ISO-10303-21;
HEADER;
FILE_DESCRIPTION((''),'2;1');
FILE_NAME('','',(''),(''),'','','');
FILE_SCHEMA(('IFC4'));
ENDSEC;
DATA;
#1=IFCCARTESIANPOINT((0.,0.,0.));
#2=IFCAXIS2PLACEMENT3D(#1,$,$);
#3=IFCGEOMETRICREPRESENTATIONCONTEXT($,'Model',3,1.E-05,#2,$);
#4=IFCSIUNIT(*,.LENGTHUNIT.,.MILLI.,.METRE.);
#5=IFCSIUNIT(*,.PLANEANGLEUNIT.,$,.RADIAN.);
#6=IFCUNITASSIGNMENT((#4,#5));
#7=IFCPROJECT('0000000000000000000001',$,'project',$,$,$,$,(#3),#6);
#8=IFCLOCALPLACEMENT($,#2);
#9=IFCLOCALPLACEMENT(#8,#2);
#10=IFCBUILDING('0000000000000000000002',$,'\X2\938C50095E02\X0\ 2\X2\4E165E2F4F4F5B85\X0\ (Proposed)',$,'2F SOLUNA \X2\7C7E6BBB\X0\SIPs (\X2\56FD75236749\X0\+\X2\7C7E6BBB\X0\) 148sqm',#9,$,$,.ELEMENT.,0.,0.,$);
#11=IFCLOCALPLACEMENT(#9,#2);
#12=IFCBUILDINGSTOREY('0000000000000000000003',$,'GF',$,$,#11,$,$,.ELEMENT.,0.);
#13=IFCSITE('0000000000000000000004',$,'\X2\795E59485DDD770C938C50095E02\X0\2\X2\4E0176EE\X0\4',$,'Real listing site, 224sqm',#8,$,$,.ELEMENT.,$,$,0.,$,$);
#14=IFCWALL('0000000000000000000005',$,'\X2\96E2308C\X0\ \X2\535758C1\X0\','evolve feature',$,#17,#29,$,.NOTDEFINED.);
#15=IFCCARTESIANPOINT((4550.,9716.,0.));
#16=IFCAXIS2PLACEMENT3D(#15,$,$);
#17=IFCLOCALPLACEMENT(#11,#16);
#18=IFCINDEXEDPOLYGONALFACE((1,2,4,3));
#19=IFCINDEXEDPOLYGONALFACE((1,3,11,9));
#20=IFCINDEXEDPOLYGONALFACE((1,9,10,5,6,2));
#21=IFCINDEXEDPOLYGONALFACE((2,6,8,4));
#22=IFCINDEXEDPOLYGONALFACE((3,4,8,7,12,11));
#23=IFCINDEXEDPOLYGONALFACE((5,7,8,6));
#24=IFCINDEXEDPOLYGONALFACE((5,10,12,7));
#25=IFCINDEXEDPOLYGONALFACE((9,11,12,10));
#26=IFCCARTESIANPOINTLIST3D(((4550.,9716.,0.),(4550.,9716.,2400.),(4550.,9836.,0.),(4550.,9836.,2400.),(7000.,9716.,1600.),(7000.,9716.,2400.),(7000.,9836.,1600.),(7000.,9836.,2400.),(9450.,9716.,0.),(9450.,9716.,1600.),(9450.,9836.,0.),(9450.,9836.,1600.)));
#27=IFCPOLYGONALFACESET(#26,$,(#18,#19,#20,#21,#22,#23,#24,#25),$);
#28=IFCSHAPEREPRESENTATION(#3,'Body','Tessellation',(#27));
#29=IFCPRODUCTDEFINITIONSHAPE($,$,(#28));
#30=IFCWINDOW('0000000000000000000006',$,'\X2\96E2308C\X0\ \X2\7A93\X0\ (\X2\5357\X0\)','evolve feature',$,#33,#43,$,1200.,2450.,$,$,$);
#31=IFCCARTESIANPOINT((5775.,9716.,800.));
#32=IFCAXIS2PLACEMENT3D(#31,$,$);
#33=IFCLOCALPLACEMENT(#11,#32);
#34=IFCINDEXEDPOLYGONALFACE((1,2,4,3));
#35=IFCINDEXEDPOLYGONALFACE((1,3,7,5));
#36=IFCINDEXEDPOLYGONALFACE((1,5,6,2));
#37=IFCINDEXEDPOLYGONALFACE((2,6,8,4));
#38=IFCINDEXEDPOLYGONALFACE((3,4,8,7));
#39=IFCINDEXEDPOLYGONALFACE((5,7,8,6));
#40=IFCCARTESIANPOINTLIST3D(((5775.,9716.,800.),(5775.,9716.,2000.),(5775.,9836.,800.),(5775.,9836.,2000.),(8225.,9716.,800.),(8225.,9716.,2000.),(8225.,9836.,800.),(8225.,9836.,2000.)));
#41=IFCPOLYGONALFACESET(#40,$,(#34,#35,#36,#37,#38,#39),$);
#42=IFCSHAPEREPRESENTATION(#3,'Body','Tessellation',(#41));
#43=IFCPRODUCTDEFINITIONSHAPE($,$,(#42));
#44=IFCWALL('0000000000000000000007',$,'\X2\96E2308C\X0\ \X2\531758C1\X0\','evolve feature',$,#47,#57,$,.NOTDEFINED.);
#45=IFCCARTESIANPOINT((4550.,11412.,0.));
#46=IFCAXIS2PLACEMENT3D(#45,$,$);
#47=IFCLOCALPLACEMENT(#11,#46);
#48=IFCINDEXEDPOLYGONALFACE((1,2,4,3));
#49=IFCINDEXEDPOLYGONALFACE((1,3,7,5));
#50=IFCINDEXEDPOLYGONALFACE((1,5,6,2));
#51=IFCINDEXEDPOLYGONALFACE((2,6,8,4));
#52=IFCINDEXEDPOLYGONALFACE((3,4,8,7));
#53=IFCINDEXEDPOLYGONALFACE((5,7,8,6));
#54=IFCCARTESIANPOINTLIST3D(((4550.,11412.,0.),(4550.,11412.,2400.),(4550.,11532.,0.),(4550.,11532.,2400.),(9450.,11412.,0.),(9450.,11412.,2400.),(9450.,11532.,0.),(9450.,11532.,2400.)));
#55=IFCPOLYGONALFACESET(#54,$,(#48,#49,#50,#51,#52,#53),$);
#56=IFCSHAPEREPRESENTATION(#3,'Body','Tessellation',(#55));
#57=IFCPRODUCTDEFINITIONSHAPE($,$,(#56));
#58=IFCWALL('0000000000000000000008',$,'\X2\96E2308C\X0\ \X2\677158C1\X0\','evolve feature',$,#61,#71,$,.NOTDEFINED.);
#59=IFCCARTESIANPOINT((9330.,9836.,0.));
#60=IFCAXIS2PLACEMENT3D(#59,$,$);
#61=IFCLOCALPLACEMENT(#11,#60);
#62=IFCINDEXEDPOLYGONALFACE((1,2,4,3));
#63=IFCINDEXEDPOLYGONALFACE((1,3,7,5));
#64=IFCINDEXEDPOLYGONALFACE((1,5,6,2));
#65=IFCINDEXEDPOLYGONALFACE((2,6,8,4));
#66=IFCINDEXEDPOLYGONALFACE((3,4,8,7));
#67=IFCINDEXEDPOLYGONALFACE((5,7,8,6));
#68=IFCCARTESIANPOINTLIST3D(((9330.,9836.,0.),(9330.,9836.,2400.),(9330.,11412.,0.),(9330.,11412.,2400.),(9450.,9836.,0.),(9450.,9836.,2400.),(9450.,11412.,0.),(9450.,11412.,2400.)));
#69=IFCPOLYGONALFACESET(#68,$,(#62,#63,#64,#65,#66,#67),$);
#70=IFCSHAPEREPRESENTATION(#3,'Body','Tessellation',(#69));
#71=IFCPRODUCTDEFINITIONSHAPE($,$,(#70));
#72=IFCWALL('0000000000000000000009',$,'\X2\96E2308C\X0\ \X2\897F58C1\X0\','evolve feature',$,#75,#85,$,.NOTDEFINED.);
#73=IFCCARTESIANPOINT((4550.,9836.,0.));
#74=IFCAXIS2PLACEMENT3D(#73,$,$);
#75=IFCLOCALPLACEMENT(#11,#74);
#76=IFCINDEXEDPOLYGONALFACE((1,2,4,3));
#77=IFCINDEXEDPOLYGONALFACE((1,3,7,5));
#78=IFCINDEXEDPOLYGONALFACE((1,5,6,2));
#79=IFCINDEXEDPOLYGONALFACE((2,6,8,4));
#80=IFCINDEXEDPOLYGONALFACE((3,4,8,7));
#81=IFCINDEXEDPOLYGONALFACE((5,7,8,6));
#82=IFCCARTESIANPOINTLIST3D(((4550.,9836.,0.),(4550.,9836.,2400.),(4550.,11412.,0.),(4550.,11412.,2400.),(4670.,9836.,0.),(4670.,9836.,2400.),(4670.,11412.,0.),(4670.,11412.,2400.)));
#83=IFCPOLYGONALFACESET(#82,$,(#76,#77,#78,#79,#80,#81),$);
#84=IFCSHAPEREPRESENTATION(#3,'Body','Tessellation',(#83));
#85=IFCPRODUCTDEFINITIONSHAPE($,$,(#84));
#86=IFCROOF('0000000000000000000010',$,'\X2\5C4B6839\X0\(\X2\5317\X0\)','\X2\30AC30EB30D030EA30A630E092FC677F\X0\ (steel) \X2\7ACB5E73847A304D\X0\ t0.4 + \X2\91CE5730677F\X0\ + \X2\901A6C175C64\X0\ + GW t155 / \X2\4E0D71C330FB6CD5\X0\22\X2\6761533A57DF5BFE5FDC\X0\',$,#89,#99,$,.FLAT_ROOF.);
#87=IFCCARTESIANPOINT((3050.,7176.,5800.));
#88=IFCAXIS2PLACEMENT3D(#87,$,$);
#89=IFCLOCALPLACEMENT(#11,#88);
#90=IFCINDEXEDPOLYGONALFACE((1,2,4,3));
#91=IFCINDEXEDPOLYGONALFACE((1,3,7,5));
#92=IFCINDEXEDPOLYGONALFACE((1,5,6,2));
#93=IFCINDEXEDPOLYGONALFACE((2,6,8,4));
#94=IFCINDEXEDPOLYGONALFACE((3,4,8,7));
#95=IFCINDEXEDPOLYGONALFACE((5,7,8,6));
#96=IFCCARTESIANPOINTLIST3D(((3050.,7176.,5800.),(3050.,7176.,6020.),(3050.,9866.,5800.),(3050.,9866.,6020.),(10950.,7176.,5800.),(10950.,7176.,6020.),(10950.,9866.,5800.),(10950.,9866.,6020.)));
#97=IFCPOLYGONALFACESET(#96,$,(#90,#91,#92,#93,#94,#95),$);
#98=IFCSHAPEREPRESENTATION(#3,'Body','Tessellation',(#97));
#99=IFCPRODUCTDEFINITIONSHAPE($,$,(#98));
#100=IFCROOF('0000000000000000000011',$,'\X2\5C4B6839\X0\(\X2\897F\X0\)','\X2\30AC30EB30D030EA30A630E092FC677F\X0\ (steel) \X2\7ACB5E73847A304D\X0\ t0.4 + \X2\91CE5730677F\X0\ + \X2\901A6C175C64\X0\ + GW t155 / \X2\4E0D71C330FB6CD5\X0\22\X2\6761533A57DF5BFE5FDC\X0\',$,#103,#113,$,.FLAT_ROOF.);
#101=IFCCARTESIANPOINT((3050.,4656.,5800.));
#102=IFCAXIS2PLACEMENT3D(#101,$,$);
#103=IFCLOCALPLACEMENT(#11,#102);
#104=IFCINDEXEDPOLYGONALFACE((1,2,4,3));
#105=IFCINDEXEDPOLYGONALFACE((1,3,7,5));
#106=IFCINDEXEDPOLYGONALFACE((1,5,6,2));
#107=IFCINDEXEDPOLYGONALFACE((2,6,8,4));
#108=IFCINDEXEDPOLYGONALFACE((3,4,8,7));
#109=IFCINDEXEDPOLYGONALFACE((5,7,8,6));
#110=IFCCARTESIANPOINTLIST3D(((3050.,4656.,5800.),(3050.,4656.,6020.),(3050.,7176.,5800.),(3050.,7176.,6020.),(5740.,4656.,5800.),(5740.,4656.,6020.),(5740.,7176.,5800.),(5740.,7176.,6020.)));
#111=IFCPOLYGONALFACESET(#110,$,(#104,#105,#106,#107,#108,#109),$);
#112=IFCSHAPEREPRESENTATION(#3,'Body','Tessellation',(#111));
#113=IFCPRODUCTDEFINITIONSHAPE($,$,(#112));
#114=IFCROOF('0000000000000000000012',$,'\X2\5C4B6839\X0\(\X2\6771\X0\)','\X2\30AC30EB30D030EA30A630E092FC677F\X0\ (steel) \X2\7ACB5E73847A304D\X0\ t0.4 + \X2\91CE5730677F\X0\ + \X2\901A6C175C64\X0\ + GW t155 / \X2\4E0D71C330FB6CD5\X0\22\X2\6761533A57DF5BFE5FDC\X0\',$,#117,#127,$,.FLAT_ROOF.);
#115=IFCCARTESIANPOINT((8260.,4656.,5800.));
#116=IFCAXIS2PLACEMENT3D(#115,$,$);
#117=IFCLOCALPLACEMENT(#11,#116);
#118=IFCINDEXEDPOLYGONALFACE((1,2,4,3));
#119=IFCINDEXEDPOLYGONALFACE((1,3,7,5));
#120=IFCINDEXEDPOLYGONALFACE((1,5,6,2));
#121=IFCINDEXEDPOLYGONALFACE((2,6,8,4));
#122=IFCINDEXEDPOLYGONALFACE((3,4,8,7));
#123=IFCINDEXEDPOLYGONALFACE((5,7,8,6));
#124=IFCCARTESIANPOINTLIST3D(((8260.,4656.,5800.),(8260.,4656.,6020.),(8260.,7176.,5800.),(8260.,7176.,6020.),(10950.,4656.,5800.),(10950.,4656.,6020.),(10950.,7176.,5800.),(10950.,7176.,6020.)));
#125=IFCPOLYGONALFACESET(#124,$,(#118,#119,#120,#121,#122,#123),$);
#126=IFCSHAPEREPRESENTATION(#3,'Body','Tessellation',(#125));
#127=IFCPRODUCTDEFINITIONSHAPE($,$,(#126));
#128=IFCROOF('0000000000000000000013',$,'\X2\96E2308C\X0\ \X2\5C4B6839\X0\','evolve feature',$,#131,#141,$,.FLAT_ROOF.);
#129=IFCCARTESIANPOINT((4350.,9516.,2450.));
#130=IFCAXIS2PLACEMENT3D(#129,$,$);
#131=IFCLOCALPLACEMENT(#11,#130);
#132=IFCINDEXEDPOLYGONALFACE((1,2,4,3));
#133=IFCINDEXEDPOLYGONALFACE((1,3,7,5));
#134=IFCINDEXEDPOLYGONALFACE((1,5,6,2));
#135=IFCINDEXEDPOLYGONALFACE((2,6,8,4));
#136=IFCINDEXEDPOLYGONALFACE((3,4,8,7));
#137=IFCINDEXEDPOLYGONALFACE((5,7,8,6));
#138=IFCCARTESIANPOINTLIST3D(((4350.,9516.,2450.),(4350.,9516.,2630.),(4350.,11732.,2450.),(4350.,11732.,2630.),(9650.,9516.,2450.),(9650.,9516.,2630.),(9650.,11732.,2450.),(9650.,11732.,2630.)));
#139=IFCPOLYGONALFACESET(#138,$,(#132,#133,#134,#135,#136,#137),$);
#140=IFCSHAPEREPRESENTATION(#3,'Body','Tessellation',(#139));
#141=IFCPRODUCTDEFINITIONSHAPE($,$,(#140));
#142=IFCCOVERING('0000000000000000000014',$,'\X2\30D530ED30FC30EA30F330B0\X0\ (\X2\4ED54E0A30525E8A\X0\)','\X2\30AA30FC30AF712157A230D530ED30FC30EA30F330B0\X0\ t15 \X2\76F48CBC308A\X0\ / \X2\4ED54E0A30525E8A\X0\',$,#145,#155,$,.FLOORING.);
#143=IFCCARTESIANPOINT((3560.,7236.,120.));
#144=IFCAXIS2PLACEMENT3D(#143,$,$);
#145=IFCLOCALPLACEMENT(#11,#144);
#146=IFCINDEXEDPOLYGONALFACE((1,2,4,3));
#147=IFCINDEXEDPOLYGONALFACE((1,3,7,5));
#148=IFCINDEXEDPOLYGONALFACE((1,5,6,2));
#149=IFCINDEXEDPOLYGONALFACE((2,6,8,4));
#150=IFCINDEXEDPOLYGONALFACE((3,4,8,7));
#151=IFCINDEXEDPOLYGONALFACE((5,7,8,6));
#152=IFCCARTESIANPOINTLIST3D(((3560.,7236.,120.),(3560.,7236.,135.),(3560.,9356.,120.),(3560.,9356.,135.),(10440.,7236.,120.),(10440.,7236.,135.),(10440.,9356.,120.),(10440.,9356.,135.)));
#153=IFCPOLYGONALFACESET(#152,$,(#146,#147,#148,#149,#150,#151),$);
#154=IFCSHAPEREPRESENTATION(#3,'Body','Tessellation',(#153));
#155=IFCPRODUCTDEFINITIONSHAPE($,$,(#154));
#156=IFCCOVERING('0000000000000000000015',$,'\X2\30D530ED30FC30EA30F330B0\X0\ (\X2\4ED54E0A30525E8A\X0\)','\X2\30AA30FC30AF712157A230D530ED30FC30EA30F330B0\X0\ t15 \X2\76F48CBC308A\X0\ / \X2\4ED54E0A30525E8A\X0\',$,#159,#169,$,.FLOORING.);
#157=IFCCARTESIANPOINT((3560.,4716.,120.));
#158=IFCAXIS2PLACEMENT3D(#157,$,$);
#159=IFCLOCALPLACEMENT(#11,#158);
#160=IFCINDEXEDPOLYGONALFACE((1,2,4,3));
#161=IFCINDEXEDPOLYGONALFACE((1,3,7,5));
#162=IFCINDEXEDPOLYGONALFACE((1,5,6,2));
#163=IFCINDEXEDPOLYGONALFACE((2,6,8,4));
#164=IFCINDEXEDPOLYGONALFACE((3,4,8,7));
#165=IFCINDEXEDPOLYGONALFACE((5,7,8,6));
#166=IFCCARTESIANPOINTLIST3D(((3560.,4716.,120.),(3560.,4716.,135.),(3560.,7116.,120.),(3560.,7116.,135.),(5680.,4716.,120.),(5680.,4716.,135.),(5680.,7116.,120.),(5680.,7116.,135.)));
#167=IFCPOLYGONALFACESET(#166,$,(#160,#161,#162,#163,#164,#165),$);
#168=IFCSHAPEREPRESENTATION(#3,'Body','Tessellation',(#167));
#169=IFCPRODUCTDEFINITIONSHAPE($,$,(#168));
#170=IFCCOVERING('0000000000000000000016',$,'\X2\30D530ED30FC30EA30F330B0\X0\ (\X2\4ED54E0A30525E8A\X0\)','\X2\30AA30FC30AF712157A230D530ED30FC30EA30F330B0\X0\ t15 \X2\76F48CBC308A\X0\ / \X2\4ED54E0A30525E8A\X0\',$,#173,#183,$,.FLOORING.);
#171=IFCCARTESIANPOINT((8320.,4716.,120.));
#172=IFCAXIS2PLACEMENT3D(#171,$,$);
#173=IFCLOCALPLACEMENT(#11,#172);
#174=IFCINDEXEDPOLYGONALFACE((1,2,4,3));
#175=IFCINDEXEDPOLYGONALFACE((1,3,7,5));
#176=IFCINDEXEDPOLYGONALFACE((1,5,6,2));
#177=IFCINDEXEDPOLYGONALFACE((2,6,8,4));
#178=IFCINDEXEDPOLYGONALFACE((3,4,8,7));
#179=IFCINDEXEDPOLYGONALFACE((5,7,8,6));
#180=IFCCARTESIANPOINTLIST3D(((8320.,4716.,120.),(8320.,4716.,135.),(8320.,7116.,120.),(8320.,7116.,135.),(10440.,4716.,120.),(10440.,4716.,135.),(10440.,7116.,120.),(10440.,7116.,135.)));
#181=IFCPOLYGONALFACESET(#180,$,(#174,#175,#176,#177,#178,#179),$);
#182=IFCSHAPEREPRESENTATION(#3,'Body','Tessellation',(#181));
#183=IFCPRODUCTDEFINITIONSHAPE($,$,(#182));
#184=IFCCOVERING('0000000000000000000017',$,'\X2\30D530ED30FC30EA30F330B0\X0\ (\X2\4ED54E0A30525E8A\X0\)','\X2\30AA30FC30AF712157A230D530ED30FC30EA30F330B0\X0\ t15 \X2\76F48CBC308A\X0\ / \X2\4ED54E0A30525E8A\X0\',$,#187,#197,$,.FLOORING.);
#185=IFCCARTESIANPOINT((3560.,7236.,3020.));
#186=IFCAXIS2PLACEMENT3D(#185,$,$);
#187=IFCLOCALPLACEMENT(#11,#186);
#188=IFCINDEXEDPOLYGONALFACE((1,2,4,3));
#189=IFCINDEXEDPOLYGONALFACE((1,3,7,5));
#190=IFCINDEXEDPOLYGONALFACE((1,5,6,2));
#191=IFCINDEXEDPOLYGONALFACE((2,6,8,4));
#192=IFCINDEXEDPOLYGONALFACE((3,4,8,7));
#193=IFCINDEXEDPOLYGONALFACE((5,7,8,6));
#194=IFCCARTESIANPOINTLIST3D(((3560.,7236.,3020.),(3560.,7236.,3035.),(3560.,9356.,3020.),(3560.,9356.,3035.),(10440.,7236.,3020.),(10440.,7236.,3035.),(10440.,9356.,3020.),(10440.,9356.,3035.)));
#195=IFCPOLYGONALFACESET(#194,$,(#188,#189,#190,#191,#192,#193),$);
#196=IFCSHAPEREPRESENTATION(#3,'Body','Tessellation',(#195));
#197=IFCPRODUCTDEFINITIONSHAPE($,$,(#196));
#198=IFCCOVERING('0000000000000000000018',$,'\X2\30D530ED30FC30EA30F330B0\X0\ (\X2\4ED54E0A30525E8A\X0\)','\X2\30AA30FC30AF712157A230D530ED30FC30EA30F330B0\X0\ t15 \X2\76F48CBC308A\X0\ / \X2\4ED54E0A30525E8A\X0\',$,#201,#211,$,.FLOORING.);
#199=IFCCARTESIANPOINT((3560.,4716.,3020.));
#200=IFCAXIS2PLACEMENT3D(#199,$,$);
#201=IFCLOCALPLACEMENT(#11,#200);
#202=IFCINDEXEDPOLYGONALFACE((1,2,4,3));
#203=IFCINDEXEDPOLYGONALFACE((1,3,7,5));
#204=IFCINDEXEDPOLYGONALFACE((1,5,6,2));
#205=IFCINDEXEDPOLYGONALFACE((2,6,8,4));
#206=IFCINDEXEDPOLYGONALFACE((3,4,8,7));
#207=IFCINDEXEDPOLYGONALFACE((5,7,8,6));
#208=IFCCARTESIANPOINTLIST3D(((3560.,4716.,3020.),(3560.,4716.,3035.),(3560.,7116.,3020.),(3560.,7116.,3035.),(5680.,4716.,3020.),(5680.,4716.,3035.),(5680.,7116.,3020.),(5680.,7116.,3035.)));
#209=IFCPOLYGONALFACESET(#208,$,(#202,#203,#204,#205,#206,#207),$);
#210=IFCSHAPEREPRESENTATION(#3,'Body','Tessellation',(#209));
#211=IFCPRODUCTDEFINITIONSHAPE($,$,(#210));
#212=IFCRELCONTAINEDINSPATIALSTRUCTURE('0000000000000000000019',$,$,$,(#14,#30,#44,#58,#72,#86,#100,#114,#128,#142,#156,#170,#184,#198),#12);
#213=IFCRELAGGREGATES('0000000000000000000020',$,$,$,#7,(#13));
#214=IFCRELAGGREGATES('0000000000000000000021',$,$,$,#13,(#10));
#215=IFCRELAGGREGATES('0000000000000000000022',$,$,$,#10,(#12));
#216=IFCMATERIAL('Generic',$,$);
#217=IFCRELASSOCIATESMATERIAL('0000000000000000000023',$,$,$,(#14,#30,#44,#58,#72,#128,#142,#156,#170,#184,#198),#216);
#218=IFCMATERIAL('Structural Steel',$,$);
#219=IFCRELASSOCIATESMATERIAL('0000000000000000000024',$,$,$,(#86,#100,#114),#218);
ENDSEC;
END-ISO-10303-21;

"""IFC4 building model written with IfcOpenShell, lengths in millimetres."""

from ifc_helpers import new_model, si_unit, frame, frame_2d, origin, place, context, project, spatial, rectangle, extrude, material, element, fill, save


model = new_model("IFC4")

# Units and contexts
model_context = context("Model", 3, precision=1e-05, world=origin())
ifc_project = project(units=[si_unit("LENGTHUNIT", "METRE", prefix="MILLI"), si_unit("PLANEANGLEUNIT", "RADIAN")], contexts=[model_context])

# Site, building, storey
site_placement = place(None, origin())
site = spatial("IfcSite", under=ifc_project, at=site_placement, Name="神奈川県鎌倉市2丁目4", ObjectType="Real listing site, 224sqm", CompositionType="ELEMENT", RefElevation=0.0)
building_placement = place(site_placement, origin())
building = spatial("IfcBuilding", under=site, at=building_placement, Name="鎌倉市 2世帯住宅 (Proposed)", ObjectType="2F SOLUNA 籾殻SIPs (国産杉+籾殻) 148sqm", CompositionType="ELEMENT", ElevationOfRefHeight=0.0, ElevationOfTerrain=0.0)
storey_placement = place(building_placement, origin())
storey = spatial("IfcBuildingStorey", under=building, at=storey_placement, Name="GF", CompositionType="ELEMENT", Elevation=0.0)

# Shared definitions
ifc_material_1 = material(Name="Generic")

# Wall, opening, window
wall_1_placement = place(storey_placement, frame((4550.0, 9716.0, 0.0)))
wall_1 = element("IfcWall", 1, at=wall_1_placement, inside=storey, material=ifc_material_1, Name="離れ 南壁", Description="evolve feature", PredefinedType="NOTDEFINED", context=model_context, shape_type="SweptSolid", body=[
    extrude(rectangle(XDim=4900.0, YDim=120.0, at=frame_2d((2450.0, 60.0))), frame((4550.0, 9716.0, 0.0)), (0.0, 0.0, 1.0), 2400.0),
])
opening_1_placement = place(storey_placement, frame((5775.0, 9716.0, 800.0)))
opening_1 = element("IfcOpeningElement", 2, at=opening_1_placement, cuts=wall_1, PredefinedType="NOTDEFINED", context=model_context, shape_type="SweptSolid", body=[
    extrude(rectangle(XDim=2450.0, YDim=120.0, at=frame_2d((1225.0, 60.0))), frame((5775.0, 9716.0, 800.0)), (0.0, 0.0, 1.0), 1200.0),
])
window_1_placement = place(storey_placement, frame((5775.0, 9716.0, 800.0)))
window_1 = element("IfcWindow", 3, at=window_1_placement, inside=storey, material=ifc_material_1, Name="離れ 窓 (南)", Description="evolve feature", OverallHeight=1200.0, OverallWidth=2450.0, context=model_context, shape_type="SweptSolid", body=[
    extrude(rectangle(XDim=2450.0, YDim=120.0, at=frame_2d((1225.0, 60.0))), frame((5775.0, 9716.0, 800.0)), (0.0, 0.0, 1.0), 1200.0),
])
fill(opening_1, window_1)

# Walls
wall_2_placement = place(storey_placement, frame((4550.0, 11412.0, 0.0)))
element("IfcWall", 4, at=wall_2_placement, inside=storey, material=ifc_material_1, Name="離れ 北壁", Description="evolve feature", PredefinedType="NOTDEFINED", context=model_context, shape_type="SweptSolid", body=[
    extrude(rectangle(XDim=4900.0, YDim=120.0, at=frame_2d((2450.0, 60.0))), frame((4550.0, 11412.0, 0.0)), (0.0, 0.0, 1.0), 2400.0),
])
wall_3_placement = place(storey_placement, frame((9330.0, 9836.0, 0.0)))
element("IfcWall", 5, at=wall_3_placement, inside=storey, material=ifc_material_1, Name="離れ 東壁", Description="evolve feature", PredefinedType="NOTDEFINED", context=model_context, shape_type="SweptSolid", body=[
    extrude(rectangle(XDim=120.0, YDim=1576.0, at=frame_2d((60.0, 788.0))), frame((9330.0, 9836.0, 0.0)), (0.0, 0.0, 1.0), 2400.0),
])
wall_4_placement = place(storey_placement, frame((4550.0, 9836.0, 0.0)))
element("IfcWall", 6, at=wall_4_placement, inside=storey, material=ifc_material_1, Name="離れ 西壁", Description="evolve feature", PredefinedType="NOTDEFINED", context=model_context, shape_type="SweptSolid", body=[
    extrude(rectangle(XDim=120.0, YDim=1576.0, at=frame_2d((60.0, 788.0))), frame((4550.0, 9836.0, 0.0)), (0.0, 0.0, 1.0), 2400.0),
])

# Roofs
ifc_material_2 = material(Name="Structural Steel")
for number, where, name in (
    (7, (3050.0, 7176.0, 5800.0), "屋根(北)"),
):
    element("IfcRoof", number, at=place(storey_placement, frame(where)), inside=storey, material=ifc_material_2, Name=name, Description="ガルバリウム鋼板 (steel) 立平葺き t0.4 + 野地板 + 通気層 + GW t155 / 不燃・法22条区域対応", PredefinedType="FLAT_ROOF", context=model_context, shape_type="SweptSolid", body=[
        extrude(rectangle(XDim=7900.0, YDim=2690.0, at=frame_2d((3950.0, 1345.0))), frame((3050.0, 7176.0, 5800.0)), (0.0, 0.0, 1.0), 220.0),
    ])
roof_1_placement = place(storey_placement, frame((3050.0, 4656.0, 5800.0)))
element("IfcRoof", 8, at=roof_1_placement, inside=storey, material=ifc_material_2, Name="屋根(西)", Description="ガルバリウム鋼板 (steel) 立平葺き t0.4 + 野地板 + 通気層 + GW t155 / 不燃・法22条区域対応", PredefinedType="FLAT_ROOF", context=model_context, shape_type="SweptSolid", body=[
    extrude(rectangle(XDim=2690.0, YDim=2520.0, at=frame_2d((1345.0, 1260.0))), frame((3050.0, 4656.0, 5800.0)), (0.0, 0.0, 1.0), 220.0),
])
roof_2_placement = place(storey_placement, frame((8260.0, 4656.0, 5800.0)))
element("IfcRoof", 9, at=roof_2_placement, inside=storey, material=ifc_material_2, Name="屋根(東)", Description="ガルバリウム鋼板 (steel) 立平葺き t0.4 + 野地板 + 通気層 + GW t155 / 不燃・法22条区域対応", PredefinedType="FLAT_ROOF", context=model_context, shape_type="SweptSolid", body=[
    extrude(rectangle(XDim=2690.0, YDim=2520.0, at=frame_2d((1345.0, 1260.0))), frame((8260.0, 4656.0, 5800.0)), (0.0, 0.0, 1.0), 220.0),
])
roof_3_placement = place(storey_placement, frame((4350.0, 9516.0, 2450.0)))
element("IfcRoof", 10, at=roof_3_placement, inside=storey, material=ifc_material_1, Name="離れ 屋根", Description="evolve feature", PredefinedType="FLAT_ROOF", context=model_context, shape_type="SweptSolid", body=[
    extrude(rectangle(XDim=5300.0, YDim=2216.0, at=frame_2d((2650.0, 1108.0))), frame((4350.0, 9516.0, 2450.0)), (0.0, 0.0, 1.0), 180.0),
])

# Coverings
covering_1_placement = place(storey_placement, frame((3560.0, 7236.0, 120.0)))
element("IfcCovering", 11, at=covering_1_placement, inside=storey, material=ifc_material_1, Name="フローリング (仕上げ床)", Description="オーク無垢フローリング t15 直貼り / 仕上げ床", PredefinedType="FLOORING", context=model_context, shape_type="SweptSolid", body=[
    extrude(rectangle(XDim=6880.0, YDim=2120.0, at=frame_2d((3440.0, 1060.0))), frame((3560.0, 7236.0, 120.0)), (0.0, 0.0, 1.0), 15.0),
])
covering_2_placement = place(storey_placement, frame((3560.0, 4716.0, 120.0)))
element("IfcCovering", 12, at=covering_2_placement, inside=storey, material=ifc_material_1, Name="フローリング (仕上げ床)", Description="オーク無垢フローリング t15 直貼り / 仕上げ床", PredefinedType="FLOORING", context=model_context, shape_type="SweptSolid", body=[
    extrude(rectangle(XDim=2120.0, YDim=2400.0, at=frame_2d((1060.0, 1200.0))), frame((3560.0, 4716.0, 120.0)), (0.0, 0.0, 1.0), 15.0),
])
covering_3_placement = place(storey_placement, frame((8320.0, 4716.0, 120.0)))
element("IfcCovering", 13, at=covering_3_placement, inside=storey, material=ifc_material_1, Name="フローリング (仕上げ床)", Description="オーク無垢フローリング t15 直貼り / 仕上げ床", PredefinedType="FLOORING", context=model_context, shape_type="SweptSolid", body=[
    extrude(rectangle(XDim=2120.0, YDim=2400.0, at=frame_2d((1060.0, 1200.0))), frame((8320.0, 4716.0, 120.0)), (0.0, 0.0, 1.0), 15.0),
])
covering_4_placement = place(storey_placement, frame((3560.0, 7236.0, 3020.0)))
element("IfcCovering", 14, at=covering_4_placement, inside=storey, material=ifc_material_1, Name="フローリング (仕上げ床)", Description="オーク無垢フローリング t15 直貼り / 仕上げ床", PredefinedType="FLOORING", context=model_context, shape_type="SweptSolid", body=[
    extrude(rectangle(XDim=6880.0, YDim=2120.0, at=frame_2d((3440.0, 1060.0))), frame((3560.0, 7236.0, 3020.0)), (0.0, 0.0, 1.0), 15.0),
])
covering_5_placement = place(storey_placement, frame((3560.0, 4716.0, 3020.0)))
element("IfcCovering", 15, at=covering_5_placement, inside=storey, material=ifc_material_1, Name="フローリング (仕上げ床)", Description="オーク無垢フローリング t15 直貼り / 仕上げ床", PredefinedType="FLOORING", context=model_context, shape_type="SweptSolid", body=[
    extrude(rectangle(XDim=2120.0, YDim=2400.0, at=frame_2d((1060.0, 1200.0))), frame((3560.0, 4716.0, 3020.0)), (0.0, 0.0, 1.0), 15.0),
])

save(model, "model.ifc")
